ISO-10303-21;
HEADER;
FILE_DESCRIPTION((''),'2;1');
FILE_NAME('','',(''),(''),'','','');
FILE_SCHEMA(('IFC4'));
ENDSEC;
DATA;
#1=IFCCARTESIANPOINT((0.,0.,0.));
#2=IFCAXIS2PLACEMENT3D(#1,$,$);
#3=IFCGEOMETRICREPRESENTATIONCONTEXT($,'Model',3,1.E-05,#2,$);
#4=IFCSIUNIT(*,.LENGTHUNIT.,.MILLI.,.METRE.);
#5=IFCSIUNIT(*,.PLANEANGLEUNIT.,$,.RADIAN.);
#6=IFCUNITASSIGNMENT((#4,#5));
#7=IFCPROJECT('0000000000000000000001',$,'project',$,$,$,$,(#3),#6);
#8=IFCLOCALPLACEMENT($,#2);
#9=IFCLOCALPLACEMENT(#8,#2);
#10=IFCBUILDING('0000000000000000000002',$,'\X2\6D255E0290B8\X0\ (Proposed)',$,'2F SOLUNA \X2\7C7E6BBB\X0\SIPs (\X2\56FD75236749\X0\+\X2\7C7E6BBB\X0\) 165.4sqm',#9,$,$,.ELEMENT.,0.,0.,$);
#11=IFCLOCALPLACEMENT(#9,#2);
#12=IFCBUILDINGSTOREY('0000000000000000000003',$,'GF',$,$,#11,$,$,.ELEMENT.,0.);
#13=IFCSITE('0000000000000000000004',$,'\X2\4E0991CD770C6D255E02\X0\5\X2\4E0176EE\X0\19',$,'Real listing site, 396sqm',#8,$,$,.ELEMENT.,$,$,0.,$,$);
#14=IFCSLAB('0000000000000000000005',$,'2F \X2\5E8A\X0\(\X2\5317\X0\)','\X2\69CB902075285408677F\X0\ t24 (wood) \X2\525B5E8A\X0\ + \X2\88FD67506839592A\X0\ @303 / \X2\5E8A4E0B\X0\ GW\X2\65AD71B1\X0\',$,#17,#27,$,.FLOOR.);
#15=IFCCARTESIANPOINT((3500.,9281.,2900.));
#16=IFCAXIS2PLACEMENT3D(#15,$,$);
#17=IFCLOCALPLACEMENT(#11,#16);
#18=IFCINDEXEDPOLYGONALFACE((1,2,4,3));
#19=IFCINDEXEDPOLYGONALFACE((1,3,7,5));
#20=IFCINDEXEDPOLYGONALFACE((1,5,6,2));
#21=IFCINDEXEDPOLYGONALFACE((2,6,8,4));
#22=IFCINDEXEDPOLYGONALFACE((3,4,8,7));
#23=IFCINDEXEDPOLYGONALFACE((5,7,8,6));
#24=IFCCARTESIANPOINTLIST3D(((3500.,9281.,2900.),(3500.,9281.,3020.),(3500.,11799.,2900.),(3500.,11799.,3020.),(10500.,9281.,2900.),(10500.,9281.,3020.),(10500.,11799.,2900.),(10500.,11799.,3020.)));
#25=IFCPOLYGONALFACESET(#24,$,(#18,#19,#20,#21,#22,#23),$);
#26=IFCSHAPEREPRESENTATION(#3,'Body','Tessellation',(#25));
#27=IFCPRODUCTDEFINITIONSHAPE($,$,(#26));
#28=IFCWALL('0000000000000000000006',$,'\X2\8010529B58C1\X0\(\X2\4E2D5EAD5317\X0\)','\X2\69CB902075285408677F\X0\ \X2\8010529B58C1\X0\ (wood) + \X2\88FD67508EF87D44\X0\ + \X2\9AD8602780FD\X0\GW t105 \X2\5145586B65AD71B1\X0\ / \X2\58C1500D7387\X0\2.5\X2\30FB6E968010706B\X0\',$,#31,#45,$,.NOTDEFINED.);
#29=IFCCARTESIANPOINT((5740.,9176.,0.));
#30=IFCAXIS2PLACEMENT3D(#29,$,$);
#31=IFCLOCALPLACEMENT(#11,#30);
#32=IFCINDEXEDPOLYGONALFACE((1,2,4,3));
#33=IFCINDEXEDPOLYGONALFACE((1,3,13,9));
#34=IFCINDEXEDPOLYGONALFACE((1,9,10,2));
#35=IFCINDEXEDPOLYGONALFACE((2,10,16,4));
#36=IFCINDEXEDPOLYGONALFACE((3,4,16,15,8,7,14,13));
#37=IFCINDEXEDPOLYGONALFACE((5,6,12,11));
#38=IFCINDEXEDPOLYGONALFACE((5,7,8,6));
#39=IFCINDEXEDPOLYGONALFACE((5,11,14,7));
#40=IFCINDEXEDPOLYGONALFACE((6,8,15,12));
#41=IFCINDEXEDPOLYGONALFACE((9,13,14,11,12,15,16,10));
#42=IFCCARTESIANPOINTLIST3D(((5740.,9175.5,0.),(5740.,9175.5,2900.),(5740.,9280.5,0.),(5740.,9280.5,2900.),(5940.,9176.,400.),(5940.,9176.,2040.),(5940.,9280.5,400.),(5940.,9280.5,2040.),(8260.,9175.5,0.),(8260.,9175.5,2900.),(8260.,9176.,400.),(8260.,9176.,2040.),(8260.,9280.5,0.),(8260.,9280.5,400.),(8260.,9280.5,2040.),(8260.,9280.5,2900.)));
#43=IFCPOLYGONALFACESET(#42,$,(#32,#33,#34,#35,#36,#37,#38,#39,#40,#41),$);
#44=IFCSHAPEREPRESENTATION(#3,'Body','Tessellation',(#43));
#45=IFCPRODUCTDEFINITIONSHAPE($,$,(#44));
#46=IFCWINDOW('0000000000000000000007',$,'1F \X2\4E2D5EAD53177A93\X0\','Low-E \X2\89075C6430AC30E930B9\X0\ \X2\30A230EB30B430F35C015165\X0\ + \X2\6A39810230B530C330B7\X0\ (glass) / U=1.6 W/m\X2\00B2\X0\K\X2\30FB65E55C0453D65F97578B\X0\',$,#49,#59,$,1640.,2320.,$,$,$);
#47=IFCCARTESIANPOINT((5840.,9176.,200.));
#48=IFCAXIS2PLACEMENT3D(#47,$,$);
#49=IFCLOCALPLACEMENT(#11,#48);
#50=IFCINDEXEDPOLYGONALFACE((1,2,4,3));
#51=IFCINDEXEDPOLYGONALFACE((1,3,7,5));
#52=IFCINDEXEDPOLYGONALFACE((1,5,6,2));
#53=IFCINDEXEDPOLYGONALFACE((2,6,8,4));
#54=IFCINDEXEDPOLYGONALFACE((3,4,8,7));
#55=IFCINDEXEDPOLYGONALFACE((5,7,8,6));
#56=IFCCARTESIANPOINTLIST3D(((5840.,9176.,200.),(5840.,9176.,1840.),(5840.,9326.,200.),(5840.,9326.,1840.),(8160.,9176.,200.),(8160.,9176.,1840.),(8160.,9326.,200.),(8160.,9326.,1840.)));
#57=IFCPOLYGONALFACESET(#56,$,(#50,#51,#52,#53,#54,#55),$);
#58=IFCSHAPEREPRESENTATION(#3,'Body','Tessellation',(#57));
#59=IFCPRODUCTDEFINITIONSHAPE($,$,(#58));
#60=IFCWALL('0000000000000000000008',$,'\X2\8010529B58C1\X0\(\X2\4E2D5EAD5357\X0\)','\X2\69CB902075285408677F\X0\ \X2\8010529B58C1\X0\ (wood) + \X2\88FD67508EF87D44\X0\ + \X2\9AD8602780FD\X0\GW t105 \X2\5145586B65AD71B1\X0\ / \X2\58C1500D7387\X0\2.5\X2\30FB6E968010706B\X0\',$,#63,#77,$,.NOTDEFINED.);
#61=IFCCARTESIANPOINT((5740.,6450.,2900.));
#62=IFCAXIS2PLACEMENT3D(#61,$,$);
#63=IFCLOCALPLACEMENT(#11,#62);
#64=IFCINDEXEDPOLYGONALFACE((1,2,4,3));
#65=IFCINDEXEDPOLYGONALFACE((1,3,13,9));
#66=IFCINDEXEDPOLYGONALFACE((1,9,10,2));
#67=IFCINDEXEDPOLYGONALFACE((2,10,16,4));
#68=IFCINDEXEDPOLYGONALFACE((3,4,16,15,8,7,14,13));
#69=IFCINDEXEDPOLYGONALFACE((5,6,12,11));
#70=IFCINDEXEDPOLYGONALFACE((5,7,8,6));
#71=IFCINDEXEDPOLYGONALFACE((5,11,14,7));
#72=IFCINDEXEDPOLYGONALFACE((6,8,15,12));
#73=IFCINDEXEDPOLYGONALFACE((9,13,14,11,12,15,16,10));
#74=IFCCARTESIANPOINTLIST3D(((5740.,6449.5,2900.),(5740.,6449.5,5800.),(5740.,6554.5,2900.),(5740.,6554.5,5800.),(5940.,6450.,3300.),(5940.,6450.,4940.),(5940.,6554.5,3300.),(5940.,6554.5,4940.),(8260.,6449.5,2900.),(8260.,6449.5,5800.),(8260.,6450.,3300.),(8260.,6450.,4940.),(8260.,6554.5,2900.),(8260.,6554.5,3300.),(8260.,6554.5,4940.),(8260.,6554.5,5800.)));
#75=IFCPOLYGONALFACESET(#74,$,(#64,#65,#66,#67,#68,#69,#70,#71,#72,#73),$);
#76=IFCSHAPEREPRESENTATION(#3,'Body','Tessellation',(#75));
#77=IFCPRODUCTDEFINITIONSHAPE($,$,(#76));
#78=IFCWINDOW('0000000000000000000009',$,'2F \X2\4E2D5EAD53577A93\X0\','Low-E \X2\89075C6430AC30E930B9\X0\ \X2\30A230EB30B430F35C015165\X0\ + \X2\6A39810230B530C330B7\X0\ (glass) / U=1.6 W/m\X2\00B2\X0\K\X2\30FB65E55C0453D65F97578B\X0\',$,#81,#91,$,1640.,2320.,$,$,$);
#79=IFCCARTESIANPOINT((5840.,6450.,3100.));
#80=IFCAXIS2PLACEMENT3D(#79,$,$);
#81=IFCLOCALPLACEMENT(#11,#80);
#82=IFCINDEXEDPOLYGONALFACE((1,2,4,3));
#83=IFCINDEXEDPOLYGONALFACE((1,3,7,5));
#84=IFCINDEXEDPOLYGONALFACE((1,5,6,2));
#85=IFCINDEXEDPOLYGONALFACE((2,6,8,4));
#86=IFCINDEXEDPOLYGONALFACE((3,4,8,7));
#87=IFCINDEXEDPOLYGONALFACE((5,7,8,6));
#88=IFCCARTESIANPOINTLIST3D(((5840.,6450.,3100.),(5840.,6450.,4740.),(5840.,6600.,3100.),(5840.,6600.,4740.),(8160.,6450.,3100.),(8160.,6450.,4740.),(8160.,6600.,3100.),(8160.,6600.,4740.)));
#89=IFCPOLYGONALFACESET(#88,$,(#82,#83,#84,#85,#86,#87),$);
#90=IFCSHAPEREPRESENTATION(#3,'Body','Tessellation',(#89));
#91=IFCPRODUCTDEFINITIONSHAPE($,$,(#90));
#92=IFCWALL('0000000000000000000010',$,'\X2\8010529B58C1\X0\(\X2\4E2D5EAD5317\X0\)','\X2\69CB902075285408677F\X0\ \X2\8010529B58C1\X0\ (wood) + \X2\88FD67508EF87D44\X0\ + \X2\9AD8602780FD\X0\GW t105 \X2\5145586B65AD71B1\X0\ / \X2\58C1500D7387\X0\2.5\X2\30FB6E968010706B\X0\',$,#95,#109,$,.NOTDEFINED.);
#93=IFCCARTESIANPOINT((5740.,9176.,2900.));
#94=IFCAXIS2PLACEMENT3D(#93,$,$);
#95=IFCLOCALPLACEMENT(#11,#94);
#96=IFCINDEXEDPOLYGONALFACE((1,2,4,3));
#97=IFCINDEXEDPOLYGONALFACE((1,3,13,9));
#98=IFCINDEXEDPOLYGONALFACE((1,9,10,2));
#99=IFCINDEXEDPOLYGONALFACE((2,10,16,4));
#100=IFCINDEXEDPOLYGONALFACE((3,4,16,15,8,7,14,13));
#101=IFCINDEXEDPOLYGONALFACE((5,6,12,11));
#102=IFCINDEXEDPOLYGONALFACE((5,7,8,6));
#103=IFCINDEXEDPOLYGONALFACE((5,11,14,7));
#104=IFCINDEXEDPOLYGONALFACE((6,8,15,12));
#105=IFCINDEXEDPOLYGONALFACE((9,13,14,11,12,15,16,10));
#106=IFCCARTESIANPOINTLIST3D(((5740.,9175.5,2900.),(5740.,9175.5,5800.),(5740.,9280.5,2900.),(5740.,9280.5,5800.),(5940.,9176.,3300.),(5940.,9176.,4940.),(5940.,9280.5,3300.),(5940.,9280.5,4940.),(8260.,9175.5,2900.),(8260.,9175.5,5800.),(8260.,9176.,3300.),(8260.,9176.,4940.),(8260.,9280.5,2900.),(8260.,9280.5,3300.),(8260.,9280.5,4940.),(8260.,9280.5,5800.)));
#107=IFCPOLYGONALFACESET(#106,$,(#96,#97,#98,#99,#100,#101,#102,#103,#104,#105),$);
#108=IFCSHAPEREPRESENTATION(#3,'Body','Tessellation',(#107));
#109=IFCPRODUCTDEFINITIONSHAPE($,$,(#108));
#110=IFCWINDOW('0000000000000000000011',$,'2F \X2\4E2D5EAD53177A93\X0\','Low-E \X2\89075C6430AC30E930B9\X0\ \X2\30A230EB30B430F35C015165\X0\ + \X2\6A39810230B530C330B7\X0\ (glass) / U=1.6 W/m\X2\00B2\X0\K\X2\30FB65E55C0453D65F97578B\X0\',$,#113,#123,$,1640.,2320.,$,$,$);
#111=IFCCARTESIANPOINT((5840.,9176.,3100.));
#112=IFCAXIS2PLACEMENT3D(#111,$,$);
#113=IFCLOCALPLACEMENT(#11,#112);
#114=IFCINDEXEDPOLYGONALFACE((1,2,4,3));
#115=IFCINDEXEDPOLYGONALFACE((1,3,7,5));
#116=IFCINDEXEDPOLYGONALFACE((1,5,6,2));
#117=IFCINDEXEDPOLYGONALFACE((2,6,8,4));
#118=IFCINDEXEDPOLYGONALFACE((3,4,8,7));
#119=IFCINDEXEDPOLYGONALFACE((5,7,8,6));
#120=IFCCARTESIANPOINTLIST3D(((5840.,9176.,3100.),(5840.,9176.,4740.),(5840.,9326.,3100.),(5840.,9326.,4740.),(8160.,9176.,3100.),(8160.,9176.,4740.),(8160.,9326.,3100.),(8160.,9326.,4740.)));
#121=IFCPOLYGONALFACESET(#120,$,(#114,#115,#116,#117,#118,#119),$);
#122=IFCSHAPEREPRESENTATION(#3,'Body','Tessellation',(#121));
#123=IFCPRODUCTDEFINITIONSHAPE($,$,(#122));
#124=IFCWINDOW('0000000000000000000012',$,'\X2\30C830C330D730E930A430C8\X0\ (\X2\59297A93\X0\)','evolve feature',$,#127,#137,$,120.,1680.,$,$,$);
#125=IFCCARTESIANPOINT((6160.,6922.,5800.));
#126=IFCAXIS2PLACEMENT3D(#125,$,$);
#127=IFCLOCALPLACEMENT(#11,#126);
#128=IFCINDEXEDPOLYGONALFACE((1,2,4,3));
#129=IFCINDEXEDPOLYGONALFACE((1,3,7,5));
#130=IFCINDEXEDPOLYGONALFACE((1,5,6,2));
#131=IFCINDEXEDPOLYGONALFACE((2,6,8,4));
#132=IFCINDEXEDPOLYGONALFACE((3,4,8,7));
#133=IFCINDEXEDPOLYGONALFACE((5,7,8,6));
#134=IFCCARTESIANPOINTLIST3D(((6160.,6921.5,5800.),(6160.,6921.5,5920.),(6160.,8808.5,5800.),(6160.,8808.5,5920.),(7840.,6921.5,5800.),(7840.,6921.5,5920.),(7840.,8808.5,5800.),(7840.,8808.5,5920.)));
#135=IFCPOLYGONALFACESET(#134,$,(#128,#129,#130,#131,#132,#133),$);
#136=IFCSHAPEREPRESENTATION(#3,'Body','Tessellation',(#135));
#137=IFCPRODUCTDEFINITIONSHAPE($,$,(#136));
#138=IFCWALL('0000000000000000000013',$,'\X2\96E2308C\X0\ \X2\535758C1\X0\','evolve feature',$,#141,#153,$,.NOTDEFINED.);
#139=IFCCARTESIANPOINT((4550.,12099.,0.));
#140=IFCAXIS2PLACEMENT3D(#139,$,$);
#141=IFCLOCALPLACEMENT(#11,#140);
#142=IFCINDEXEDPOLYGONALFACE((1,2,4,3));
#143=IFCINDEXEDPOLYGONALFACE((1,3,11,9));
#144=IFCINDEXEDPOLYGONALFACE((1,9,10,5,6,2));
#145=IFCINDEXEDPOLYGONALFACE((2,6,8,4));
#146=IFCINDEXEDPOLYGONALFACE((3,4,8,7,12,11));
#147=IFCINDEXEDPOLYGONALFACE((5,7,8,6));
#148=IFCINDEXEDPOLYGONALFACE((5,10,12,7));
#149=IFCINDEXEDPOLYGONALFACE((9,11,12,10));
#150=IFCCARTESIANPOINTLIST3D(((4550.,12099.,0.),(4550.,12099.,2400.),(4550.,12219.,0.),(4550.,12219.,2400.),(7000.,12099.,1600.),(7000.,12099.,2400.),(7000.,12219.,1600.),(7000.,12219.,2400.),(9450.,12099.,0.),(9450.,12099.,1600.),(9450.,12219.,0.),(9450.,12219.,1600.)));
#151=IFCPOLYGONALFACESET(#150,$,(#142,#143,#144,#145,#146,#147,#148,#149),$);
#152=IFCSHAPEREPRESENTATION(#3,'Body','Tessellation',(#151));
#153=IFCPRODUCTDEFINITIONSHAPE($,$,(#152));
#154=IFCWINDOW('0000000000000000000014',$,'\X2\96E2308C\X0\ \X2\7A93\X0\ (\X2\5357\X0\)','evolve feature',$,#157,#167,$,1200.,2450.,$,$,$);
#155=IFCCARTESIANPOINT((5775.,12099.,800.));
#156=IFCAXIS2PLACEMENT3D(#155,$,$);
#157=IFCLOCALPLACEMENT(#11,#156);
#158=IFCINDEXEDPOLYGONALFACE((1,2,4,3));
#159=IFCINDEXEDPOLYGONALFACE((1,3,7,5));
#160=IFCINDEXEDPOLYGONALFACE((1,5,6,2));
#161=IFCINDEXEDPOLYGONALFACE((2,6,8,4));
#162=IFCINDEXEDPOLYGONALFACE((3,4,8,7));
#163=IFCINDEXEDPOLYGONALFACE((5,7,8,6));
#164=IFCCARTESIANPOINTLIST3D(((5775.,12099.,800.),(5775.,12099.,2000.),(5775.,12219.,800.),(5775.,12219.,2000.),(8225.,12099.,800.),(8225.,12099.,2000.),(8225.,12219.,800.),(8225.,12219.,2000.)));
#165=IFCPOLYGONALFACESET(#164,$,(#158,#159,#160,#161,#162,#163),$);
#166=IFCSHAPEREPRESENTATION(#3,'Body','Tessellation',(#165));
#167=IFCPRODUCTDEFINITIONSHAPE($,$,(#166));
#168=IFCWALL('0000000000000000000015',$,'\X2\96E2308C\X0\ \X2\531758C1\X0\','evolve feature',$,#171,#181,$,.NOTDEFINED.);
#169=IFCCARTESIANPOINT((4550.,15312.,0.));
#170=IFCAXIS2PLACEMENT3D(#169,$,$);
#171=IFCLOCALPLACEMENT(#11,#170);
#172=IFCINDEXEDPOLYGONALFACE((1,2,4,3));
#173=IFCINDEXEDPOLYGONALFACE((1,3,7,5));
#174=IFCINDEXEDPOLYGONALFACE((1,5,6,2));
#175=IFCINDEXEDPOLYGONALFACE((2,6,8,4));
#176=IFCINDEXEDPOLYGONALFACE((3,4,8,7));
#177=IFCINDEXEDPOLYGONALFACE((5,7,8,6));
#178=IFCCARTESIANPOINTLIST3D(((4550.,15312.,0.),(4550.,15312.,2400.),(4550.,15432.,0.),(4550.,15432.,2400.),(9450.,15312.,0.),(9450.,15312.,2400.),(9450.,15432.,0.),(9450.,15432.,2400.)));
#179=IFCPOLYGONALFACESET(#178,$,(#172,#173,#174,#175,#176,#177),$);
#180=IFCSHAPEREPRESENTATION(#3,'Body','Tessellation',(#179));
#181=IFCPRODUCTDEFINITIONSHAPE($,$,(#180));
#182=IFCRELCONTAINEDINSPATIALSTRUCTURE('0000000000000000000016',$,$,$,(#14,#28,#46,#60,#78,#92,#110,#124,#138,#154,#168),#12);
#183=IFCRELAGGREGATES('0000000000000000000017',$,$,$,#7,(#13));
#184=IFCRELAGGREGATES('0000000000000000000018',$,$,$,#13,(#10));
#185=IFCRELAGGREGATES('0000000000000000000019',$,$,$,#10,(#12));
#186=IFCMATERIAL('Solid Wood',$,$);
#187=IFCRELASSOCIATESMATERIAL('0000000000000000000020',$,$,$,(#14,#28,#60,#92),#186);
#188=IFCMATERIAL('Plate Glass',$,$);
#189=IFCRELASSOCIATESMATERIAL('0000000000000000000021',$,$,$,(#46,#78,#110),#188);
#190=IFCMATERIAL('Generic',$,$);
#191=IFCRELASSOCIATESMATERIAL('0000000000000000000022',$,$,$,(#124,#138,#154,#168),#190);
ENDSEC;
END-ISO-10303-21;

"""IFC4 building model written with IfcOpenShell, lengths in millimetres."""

from ifc_helpers import new_model, si_unit, frame, frame_2d, origin, place, context, project, spatial, rectangle, extrude, material, element, fill, save


model = new_model("IFC4")

# Units and contexts
model_context = context("Model", 3, precision=1e-05, world=origin())
ifc_project = project(units=[si_unit("LENGTHUNIT", "METRE", prefix="MILLI"), si_unit("PLANEANGLEUNIT", "RADIAN")], contexts=[model_context])

# Site, building, storey
site_placement = place(None, origin())
site = spatial("IfcSite", under=ifc_project, at=site_placement, Name="三重県津市5丁目19", ObjectType="Real listing site, 396sqm", CompositionType="ELEMENT", RefElevation=0.0)
building_placement = place(site_placement, origin())
building = spatial("IfcBuilding", under=site, at=building_placement, Name="津市邸 (Proposed)", ObjectType="2F SOLUNA 籾殻SIPs (国産杉+籾殻) 165.4sqm", CompositionType="ELEMENT", ElevationOfRefHeight=0.0, ElevationOfTerrain=0.0)
storey_placement = place(building_placement, origin())
storey = spatial("IfcBuildingStorey", under=building, at=storey_placement, Name="GF", CompositionType="ELEMENT", Elevation=0.0)

# Slab
ifc_material_1 = material(Name="Solid Wood")
slab_1_placement = place(storey_placement, frame((3500.0, 9281.0, 2900.0)))
element("IfcSlab", 1, at=slab_1_placement, inside=storey, material=ifc_material_1, Name="2F 床(北)", Description="構造用合板 t24 (wood) 剛床 + 製材根太 @303 / 床下 GW断熱", PredefinedType="FLOOR", context=model_context, shape_type="SweptSolid", body=[
    extrude(rectangle(XDim=7000.0, YDim=2518.0, at=frame_2d((3500.0, 1259.0))), frame((3500.0, 9281.0, 2900.0)), (0.0, 0.0, 1.0), 120.0),
])
ifc_material_2 = material(Name="Generic")

# Wall, opening, window
wall_1_placement = place(storey_placement, frame((5740.0, 9176.0, 0.0)))
wall_1 = element("IfcWall", 2, at=wall_1_placement, inside=storey, material=ifc_material_1, Name="耐力壁(中庭北)", Description="構造用合板 耐力壁 (wood) + 製材軸組 + 高性能GW t105 充填断熱 / 壁倍率2.5・準耐火", PredefinedType="NOTDEFINED", context=model_context, shape_type="SweptSolid", body=[
    extrude(rectangle(XDim=2520.0, YDim=105.0, at=frame_2d((1260.0, 52.0))), frame((5740.0, 9176.0, 0.0)), (0.0, 0.0, 1.0), 2900.0),
])
opening_1_placement = place(storey_placement, frame((5840.0, 9176.0, 200.0)))
opening_1 = element("IfcOpeningElement", 3, at=opening_1_placement, cuts=wall_1, PredefinedType="NOTDEFINED", context=model_context, shape_type="SweptSolid", body=[
    extrude(rectangle(XDim=2320.0, YDim=150.0, at=frame_2d((1160.0, 75.0))), frame((5840.0, 9176.0, 200.0)), (0.0, 0.0, 1.0), 1640.0),
])
ifc_material_3 = material(Name="Plate Glass")
window_1_placement = place(storey_placement, frame((5840.0, 9176.0, 200.0)))
window_1 = element("IfcWindow", 4, at=window_1_placement, inside=storey, material=ifc_material_3, Name="1F 中庭北窓", Description="Low-E 複層ガラス アルゴン封入 + 樹脂サッシ (glass) / U=1.6 W/m²K・日射取得型", OverallHeight=1640.0, OverallWidth=2320.0, context=model_context, shape_type="SweptSolid", body=[
    extrude(rectangle(XDim=2320.0, YDim=150.0, at=frame_2d((1160.0, 75.0))), frame((5840.0, 9176.0, 200.0)), (0.0, 0.0, 1.0), 1640.0),
])
fill(opening_1, window_1)

# Walls, openings, windows
wall_2_placement = place(storey_placement, frame((5740.0, 6450.0, 2900.0)))
wall_2 = element("IfcWall", 5, at=wall_2_placement, inside=storey, material=ifc_material_1, Name="耐力壁(中庭南)", Description="構造用合板 耐力壁 (wood) + 製材軸組 + 高性能GW t105 充填断熱 / 壁倍率2.5・準耐火", PredefinedType="NOTDEFINED", context=model_context, shape_type="SweptSolid", body=[
    extrude(rectangle(XDim=2520.0, YDim=105.0, at=frame_2d((1260.0, 52.0))), frame((5740.0, 6450.0, 2900.0)), (0.0, 0.0, 1.0), 2900.0),
])
opening_2_placement = place(storey_placement, frame((5840.0, 6450.0, 3100.0)))
opening_2 = element("IfcOpeningElement", 6, at=opening_2_placement, cuts=wall_2, PredefinedType="NOTDEFINED", context=model_context, shape_type="SweptSolid", body=[
    extrude(rectangle(XDim=2320.0, YDim=150.0, at=frame_2d((1160.0, 75.0))), frame((5840.0, 6450.0, 3100.0)), (0.0, 0.0, 1.0), 1640.0),
])
window_2_placement = place(storey_placement, frame((5840.0, 6450.0, 3100.0)))
window_2 = element("IfcWindow", 7, at=window_2_placement, inside=storey, material=ifc_material_3, Name="2F 中庭南窓", Description="Low-E 複層ガラス アルゴン封入 + 樹脂サッシ (glass) / U=1.6 W/m²K・日射取得型", OverallHeight=1640.0, OverallWidth=2320.0, context=model_context, shape_type="SweptSolid", body=[
    extrude(rectangle(XDim=2320.0, YDim=150.0, at=frame_2d((1160.0, 75.0))), frame((5840.0, 6450.0, 3100.0)), (0.0, 0.0, 1.0), 1640.0),
])
fill(opening_2, window_2)
wall_3_placement = place(storey_placement, frame((5740.0, 9176.0, 2900.0)))
wall_3 = element("IfcWall", 8, at=wall_3_placement, inside=storey, material=ifc_material_1, Name="耐力壁(中庭北)", Description="構造用合板 耐力壁 (wood) + 製材軸組 + 高性能GW t105 充填断熱 / 壁倍率2.5・準耐火", PredefinedType="NOTDEFINED", context=model_context, shape_type="SweptSolid", body=[
    extrude(rectangle(XDim=2520.0, YDim=105.0, at=frame_2d((1260.0, 52.0))), frame((5740.0, 9176.0, 2900.0)), (0.0, 0.0, 1.0), 2900.0),
])
opening_3_placement = place(storey_placement, frame((5840.0, 9176.0, 3100.0)))
opening_3 = element("IfcOpeningElement", 9, at=opening_3_placement, cuts=wall_3, PredefinedType="NOTDEFINED", context=model_context, shape_type="SweptSolid", body=[
    extrude(rectangle(XDim=2320.0, YDim=150.0, at=frame_2d((1160.0, 75.0))), frame((5840.0, 9176.0, 3100.0)), (0.0, 0.0, 1.0), 1640.0),
])
window_3_placement = place(storey_placement, frame((5840.0, 9176.0, 3100.0)))
window_3 = element("IfcWindow", 10, at=window_3_placement, inside=storey, material=ifc_material_3, Name="2F 中庭北窓", Description="Low-E 複層ガラス アルゴン封入 + 樹脂サッシ (glass) / U=1.6 W/m²K・日射取得型", OverallHeight=1640.0, OverallWidth=2320.0, context=model_context, shape_type="SweptSolid", body=[
    extrude(rectangle(XDim=2320.0, YDim=150.0, at=frame_2d((1160.0, 75.0))), frame((5840.0, 9176.0, 3100.0)), (0.0, 0.0, 1.0), 1640.0),
])
fill(opening_3, window_3)

# Window
window_4_placement = place(storey_placement, frame((6160.0, 6922.0, 5800.0)))
element("IfcWindow", 11, at=window_4_placement, inside=storey, material=ifc_material_2, Name="トップライト (天窓)", Description="evolve feature", OverallHeight=120.0, OverallWidth=1680.0, context=model_context, shape_type="SweptSolid", body=[
    extrude(rectangle(XDim=1680.0, YDim=1887.0, at=frame_2d((840.0, 943.0))), frame((6160.0, 6922.0, 5800.0)), (0.0, 0.0, 1.0), 120.0),
])

# Wall, opening, window
wall_4_placement = place(storey_placement, frame((4550.0, 12099.0, 0.0)))
wall_4 = element("IfcWall", 12, at=wall_4_placement, inside=storey, material=ifc_material_2, Name="離れ 南壁", Description="evolve feature", PredefinedType="NOTDEFINED", context=model_context, shape_type="SweptSolid", body=[
    extrude(rectangle(XDim=4900.0, YDim=120.0, at=frame_2d((2450.0, 60.0))), frame((4550.0, 12099.0, 0.0)), (0.0, 0.0, 1.0), 2400.0),
])
opening_4_placement = place(storey_placement, frame((5775.0, 12099.0, 800.0)))
opening_4 = element("IfcOpeningElement", 13, at=opening_4_placement, cuts=wall_4, PredefinedType="NOTDEFINED", context=model_context, shape_type="SweptSolid", body=[
    extrude(rectangle(XDim=2450.0, YDim=120.0, at=frame_2d((1225.0, 60.0))), frame((5775.0, 12099.0, 800.0)), (0.0, 0.0, 1.0), 1200.0),
])
window_5_placement = place(storey_placement, frame((5775.0, 12099.0, 800.0)))
window_5 = element("IfcWindow", 14, at=window_5_placement, inside=storey, material=ifc_material_2, Name="離れ 窓 (南)", Description="evolve feature", OverallHeight=1200.0, OverallWidth=2450.0, context=model_context, shape_type="SweptSolid", body=[
    extrude(rectangle(XDim=2450.0, YDim=120.0, at=frame_2d((1225.0, 60.0))), frame((5775.0, 12099.0, 800.0)), (0.0, 0.0, 1.0), 1200.0),
])
fill(opening_4, window_5)

# Wall
wall_5_placement = place(storey_placement, frame((4550.0, 15312.0, 0.0)))
element("IfcWall", 15, at=wall_5_placement, inside=storey, material=ifc_material_2, Name="離れ 北壁", Description="evolve feature", PredefinedType="NOTDEFINED", context=model_context, shape_type="SweptSolid", body=[
    extrude(rectangle(XDim=4900.0, YDim=120.0, at=frame_2d((2450.0, 60.0))), frame((4550.0, 15312.0, 0.0)), (0.0, 0.0, 1.0), 2400.0),
])

save(model, "model.ifc")
